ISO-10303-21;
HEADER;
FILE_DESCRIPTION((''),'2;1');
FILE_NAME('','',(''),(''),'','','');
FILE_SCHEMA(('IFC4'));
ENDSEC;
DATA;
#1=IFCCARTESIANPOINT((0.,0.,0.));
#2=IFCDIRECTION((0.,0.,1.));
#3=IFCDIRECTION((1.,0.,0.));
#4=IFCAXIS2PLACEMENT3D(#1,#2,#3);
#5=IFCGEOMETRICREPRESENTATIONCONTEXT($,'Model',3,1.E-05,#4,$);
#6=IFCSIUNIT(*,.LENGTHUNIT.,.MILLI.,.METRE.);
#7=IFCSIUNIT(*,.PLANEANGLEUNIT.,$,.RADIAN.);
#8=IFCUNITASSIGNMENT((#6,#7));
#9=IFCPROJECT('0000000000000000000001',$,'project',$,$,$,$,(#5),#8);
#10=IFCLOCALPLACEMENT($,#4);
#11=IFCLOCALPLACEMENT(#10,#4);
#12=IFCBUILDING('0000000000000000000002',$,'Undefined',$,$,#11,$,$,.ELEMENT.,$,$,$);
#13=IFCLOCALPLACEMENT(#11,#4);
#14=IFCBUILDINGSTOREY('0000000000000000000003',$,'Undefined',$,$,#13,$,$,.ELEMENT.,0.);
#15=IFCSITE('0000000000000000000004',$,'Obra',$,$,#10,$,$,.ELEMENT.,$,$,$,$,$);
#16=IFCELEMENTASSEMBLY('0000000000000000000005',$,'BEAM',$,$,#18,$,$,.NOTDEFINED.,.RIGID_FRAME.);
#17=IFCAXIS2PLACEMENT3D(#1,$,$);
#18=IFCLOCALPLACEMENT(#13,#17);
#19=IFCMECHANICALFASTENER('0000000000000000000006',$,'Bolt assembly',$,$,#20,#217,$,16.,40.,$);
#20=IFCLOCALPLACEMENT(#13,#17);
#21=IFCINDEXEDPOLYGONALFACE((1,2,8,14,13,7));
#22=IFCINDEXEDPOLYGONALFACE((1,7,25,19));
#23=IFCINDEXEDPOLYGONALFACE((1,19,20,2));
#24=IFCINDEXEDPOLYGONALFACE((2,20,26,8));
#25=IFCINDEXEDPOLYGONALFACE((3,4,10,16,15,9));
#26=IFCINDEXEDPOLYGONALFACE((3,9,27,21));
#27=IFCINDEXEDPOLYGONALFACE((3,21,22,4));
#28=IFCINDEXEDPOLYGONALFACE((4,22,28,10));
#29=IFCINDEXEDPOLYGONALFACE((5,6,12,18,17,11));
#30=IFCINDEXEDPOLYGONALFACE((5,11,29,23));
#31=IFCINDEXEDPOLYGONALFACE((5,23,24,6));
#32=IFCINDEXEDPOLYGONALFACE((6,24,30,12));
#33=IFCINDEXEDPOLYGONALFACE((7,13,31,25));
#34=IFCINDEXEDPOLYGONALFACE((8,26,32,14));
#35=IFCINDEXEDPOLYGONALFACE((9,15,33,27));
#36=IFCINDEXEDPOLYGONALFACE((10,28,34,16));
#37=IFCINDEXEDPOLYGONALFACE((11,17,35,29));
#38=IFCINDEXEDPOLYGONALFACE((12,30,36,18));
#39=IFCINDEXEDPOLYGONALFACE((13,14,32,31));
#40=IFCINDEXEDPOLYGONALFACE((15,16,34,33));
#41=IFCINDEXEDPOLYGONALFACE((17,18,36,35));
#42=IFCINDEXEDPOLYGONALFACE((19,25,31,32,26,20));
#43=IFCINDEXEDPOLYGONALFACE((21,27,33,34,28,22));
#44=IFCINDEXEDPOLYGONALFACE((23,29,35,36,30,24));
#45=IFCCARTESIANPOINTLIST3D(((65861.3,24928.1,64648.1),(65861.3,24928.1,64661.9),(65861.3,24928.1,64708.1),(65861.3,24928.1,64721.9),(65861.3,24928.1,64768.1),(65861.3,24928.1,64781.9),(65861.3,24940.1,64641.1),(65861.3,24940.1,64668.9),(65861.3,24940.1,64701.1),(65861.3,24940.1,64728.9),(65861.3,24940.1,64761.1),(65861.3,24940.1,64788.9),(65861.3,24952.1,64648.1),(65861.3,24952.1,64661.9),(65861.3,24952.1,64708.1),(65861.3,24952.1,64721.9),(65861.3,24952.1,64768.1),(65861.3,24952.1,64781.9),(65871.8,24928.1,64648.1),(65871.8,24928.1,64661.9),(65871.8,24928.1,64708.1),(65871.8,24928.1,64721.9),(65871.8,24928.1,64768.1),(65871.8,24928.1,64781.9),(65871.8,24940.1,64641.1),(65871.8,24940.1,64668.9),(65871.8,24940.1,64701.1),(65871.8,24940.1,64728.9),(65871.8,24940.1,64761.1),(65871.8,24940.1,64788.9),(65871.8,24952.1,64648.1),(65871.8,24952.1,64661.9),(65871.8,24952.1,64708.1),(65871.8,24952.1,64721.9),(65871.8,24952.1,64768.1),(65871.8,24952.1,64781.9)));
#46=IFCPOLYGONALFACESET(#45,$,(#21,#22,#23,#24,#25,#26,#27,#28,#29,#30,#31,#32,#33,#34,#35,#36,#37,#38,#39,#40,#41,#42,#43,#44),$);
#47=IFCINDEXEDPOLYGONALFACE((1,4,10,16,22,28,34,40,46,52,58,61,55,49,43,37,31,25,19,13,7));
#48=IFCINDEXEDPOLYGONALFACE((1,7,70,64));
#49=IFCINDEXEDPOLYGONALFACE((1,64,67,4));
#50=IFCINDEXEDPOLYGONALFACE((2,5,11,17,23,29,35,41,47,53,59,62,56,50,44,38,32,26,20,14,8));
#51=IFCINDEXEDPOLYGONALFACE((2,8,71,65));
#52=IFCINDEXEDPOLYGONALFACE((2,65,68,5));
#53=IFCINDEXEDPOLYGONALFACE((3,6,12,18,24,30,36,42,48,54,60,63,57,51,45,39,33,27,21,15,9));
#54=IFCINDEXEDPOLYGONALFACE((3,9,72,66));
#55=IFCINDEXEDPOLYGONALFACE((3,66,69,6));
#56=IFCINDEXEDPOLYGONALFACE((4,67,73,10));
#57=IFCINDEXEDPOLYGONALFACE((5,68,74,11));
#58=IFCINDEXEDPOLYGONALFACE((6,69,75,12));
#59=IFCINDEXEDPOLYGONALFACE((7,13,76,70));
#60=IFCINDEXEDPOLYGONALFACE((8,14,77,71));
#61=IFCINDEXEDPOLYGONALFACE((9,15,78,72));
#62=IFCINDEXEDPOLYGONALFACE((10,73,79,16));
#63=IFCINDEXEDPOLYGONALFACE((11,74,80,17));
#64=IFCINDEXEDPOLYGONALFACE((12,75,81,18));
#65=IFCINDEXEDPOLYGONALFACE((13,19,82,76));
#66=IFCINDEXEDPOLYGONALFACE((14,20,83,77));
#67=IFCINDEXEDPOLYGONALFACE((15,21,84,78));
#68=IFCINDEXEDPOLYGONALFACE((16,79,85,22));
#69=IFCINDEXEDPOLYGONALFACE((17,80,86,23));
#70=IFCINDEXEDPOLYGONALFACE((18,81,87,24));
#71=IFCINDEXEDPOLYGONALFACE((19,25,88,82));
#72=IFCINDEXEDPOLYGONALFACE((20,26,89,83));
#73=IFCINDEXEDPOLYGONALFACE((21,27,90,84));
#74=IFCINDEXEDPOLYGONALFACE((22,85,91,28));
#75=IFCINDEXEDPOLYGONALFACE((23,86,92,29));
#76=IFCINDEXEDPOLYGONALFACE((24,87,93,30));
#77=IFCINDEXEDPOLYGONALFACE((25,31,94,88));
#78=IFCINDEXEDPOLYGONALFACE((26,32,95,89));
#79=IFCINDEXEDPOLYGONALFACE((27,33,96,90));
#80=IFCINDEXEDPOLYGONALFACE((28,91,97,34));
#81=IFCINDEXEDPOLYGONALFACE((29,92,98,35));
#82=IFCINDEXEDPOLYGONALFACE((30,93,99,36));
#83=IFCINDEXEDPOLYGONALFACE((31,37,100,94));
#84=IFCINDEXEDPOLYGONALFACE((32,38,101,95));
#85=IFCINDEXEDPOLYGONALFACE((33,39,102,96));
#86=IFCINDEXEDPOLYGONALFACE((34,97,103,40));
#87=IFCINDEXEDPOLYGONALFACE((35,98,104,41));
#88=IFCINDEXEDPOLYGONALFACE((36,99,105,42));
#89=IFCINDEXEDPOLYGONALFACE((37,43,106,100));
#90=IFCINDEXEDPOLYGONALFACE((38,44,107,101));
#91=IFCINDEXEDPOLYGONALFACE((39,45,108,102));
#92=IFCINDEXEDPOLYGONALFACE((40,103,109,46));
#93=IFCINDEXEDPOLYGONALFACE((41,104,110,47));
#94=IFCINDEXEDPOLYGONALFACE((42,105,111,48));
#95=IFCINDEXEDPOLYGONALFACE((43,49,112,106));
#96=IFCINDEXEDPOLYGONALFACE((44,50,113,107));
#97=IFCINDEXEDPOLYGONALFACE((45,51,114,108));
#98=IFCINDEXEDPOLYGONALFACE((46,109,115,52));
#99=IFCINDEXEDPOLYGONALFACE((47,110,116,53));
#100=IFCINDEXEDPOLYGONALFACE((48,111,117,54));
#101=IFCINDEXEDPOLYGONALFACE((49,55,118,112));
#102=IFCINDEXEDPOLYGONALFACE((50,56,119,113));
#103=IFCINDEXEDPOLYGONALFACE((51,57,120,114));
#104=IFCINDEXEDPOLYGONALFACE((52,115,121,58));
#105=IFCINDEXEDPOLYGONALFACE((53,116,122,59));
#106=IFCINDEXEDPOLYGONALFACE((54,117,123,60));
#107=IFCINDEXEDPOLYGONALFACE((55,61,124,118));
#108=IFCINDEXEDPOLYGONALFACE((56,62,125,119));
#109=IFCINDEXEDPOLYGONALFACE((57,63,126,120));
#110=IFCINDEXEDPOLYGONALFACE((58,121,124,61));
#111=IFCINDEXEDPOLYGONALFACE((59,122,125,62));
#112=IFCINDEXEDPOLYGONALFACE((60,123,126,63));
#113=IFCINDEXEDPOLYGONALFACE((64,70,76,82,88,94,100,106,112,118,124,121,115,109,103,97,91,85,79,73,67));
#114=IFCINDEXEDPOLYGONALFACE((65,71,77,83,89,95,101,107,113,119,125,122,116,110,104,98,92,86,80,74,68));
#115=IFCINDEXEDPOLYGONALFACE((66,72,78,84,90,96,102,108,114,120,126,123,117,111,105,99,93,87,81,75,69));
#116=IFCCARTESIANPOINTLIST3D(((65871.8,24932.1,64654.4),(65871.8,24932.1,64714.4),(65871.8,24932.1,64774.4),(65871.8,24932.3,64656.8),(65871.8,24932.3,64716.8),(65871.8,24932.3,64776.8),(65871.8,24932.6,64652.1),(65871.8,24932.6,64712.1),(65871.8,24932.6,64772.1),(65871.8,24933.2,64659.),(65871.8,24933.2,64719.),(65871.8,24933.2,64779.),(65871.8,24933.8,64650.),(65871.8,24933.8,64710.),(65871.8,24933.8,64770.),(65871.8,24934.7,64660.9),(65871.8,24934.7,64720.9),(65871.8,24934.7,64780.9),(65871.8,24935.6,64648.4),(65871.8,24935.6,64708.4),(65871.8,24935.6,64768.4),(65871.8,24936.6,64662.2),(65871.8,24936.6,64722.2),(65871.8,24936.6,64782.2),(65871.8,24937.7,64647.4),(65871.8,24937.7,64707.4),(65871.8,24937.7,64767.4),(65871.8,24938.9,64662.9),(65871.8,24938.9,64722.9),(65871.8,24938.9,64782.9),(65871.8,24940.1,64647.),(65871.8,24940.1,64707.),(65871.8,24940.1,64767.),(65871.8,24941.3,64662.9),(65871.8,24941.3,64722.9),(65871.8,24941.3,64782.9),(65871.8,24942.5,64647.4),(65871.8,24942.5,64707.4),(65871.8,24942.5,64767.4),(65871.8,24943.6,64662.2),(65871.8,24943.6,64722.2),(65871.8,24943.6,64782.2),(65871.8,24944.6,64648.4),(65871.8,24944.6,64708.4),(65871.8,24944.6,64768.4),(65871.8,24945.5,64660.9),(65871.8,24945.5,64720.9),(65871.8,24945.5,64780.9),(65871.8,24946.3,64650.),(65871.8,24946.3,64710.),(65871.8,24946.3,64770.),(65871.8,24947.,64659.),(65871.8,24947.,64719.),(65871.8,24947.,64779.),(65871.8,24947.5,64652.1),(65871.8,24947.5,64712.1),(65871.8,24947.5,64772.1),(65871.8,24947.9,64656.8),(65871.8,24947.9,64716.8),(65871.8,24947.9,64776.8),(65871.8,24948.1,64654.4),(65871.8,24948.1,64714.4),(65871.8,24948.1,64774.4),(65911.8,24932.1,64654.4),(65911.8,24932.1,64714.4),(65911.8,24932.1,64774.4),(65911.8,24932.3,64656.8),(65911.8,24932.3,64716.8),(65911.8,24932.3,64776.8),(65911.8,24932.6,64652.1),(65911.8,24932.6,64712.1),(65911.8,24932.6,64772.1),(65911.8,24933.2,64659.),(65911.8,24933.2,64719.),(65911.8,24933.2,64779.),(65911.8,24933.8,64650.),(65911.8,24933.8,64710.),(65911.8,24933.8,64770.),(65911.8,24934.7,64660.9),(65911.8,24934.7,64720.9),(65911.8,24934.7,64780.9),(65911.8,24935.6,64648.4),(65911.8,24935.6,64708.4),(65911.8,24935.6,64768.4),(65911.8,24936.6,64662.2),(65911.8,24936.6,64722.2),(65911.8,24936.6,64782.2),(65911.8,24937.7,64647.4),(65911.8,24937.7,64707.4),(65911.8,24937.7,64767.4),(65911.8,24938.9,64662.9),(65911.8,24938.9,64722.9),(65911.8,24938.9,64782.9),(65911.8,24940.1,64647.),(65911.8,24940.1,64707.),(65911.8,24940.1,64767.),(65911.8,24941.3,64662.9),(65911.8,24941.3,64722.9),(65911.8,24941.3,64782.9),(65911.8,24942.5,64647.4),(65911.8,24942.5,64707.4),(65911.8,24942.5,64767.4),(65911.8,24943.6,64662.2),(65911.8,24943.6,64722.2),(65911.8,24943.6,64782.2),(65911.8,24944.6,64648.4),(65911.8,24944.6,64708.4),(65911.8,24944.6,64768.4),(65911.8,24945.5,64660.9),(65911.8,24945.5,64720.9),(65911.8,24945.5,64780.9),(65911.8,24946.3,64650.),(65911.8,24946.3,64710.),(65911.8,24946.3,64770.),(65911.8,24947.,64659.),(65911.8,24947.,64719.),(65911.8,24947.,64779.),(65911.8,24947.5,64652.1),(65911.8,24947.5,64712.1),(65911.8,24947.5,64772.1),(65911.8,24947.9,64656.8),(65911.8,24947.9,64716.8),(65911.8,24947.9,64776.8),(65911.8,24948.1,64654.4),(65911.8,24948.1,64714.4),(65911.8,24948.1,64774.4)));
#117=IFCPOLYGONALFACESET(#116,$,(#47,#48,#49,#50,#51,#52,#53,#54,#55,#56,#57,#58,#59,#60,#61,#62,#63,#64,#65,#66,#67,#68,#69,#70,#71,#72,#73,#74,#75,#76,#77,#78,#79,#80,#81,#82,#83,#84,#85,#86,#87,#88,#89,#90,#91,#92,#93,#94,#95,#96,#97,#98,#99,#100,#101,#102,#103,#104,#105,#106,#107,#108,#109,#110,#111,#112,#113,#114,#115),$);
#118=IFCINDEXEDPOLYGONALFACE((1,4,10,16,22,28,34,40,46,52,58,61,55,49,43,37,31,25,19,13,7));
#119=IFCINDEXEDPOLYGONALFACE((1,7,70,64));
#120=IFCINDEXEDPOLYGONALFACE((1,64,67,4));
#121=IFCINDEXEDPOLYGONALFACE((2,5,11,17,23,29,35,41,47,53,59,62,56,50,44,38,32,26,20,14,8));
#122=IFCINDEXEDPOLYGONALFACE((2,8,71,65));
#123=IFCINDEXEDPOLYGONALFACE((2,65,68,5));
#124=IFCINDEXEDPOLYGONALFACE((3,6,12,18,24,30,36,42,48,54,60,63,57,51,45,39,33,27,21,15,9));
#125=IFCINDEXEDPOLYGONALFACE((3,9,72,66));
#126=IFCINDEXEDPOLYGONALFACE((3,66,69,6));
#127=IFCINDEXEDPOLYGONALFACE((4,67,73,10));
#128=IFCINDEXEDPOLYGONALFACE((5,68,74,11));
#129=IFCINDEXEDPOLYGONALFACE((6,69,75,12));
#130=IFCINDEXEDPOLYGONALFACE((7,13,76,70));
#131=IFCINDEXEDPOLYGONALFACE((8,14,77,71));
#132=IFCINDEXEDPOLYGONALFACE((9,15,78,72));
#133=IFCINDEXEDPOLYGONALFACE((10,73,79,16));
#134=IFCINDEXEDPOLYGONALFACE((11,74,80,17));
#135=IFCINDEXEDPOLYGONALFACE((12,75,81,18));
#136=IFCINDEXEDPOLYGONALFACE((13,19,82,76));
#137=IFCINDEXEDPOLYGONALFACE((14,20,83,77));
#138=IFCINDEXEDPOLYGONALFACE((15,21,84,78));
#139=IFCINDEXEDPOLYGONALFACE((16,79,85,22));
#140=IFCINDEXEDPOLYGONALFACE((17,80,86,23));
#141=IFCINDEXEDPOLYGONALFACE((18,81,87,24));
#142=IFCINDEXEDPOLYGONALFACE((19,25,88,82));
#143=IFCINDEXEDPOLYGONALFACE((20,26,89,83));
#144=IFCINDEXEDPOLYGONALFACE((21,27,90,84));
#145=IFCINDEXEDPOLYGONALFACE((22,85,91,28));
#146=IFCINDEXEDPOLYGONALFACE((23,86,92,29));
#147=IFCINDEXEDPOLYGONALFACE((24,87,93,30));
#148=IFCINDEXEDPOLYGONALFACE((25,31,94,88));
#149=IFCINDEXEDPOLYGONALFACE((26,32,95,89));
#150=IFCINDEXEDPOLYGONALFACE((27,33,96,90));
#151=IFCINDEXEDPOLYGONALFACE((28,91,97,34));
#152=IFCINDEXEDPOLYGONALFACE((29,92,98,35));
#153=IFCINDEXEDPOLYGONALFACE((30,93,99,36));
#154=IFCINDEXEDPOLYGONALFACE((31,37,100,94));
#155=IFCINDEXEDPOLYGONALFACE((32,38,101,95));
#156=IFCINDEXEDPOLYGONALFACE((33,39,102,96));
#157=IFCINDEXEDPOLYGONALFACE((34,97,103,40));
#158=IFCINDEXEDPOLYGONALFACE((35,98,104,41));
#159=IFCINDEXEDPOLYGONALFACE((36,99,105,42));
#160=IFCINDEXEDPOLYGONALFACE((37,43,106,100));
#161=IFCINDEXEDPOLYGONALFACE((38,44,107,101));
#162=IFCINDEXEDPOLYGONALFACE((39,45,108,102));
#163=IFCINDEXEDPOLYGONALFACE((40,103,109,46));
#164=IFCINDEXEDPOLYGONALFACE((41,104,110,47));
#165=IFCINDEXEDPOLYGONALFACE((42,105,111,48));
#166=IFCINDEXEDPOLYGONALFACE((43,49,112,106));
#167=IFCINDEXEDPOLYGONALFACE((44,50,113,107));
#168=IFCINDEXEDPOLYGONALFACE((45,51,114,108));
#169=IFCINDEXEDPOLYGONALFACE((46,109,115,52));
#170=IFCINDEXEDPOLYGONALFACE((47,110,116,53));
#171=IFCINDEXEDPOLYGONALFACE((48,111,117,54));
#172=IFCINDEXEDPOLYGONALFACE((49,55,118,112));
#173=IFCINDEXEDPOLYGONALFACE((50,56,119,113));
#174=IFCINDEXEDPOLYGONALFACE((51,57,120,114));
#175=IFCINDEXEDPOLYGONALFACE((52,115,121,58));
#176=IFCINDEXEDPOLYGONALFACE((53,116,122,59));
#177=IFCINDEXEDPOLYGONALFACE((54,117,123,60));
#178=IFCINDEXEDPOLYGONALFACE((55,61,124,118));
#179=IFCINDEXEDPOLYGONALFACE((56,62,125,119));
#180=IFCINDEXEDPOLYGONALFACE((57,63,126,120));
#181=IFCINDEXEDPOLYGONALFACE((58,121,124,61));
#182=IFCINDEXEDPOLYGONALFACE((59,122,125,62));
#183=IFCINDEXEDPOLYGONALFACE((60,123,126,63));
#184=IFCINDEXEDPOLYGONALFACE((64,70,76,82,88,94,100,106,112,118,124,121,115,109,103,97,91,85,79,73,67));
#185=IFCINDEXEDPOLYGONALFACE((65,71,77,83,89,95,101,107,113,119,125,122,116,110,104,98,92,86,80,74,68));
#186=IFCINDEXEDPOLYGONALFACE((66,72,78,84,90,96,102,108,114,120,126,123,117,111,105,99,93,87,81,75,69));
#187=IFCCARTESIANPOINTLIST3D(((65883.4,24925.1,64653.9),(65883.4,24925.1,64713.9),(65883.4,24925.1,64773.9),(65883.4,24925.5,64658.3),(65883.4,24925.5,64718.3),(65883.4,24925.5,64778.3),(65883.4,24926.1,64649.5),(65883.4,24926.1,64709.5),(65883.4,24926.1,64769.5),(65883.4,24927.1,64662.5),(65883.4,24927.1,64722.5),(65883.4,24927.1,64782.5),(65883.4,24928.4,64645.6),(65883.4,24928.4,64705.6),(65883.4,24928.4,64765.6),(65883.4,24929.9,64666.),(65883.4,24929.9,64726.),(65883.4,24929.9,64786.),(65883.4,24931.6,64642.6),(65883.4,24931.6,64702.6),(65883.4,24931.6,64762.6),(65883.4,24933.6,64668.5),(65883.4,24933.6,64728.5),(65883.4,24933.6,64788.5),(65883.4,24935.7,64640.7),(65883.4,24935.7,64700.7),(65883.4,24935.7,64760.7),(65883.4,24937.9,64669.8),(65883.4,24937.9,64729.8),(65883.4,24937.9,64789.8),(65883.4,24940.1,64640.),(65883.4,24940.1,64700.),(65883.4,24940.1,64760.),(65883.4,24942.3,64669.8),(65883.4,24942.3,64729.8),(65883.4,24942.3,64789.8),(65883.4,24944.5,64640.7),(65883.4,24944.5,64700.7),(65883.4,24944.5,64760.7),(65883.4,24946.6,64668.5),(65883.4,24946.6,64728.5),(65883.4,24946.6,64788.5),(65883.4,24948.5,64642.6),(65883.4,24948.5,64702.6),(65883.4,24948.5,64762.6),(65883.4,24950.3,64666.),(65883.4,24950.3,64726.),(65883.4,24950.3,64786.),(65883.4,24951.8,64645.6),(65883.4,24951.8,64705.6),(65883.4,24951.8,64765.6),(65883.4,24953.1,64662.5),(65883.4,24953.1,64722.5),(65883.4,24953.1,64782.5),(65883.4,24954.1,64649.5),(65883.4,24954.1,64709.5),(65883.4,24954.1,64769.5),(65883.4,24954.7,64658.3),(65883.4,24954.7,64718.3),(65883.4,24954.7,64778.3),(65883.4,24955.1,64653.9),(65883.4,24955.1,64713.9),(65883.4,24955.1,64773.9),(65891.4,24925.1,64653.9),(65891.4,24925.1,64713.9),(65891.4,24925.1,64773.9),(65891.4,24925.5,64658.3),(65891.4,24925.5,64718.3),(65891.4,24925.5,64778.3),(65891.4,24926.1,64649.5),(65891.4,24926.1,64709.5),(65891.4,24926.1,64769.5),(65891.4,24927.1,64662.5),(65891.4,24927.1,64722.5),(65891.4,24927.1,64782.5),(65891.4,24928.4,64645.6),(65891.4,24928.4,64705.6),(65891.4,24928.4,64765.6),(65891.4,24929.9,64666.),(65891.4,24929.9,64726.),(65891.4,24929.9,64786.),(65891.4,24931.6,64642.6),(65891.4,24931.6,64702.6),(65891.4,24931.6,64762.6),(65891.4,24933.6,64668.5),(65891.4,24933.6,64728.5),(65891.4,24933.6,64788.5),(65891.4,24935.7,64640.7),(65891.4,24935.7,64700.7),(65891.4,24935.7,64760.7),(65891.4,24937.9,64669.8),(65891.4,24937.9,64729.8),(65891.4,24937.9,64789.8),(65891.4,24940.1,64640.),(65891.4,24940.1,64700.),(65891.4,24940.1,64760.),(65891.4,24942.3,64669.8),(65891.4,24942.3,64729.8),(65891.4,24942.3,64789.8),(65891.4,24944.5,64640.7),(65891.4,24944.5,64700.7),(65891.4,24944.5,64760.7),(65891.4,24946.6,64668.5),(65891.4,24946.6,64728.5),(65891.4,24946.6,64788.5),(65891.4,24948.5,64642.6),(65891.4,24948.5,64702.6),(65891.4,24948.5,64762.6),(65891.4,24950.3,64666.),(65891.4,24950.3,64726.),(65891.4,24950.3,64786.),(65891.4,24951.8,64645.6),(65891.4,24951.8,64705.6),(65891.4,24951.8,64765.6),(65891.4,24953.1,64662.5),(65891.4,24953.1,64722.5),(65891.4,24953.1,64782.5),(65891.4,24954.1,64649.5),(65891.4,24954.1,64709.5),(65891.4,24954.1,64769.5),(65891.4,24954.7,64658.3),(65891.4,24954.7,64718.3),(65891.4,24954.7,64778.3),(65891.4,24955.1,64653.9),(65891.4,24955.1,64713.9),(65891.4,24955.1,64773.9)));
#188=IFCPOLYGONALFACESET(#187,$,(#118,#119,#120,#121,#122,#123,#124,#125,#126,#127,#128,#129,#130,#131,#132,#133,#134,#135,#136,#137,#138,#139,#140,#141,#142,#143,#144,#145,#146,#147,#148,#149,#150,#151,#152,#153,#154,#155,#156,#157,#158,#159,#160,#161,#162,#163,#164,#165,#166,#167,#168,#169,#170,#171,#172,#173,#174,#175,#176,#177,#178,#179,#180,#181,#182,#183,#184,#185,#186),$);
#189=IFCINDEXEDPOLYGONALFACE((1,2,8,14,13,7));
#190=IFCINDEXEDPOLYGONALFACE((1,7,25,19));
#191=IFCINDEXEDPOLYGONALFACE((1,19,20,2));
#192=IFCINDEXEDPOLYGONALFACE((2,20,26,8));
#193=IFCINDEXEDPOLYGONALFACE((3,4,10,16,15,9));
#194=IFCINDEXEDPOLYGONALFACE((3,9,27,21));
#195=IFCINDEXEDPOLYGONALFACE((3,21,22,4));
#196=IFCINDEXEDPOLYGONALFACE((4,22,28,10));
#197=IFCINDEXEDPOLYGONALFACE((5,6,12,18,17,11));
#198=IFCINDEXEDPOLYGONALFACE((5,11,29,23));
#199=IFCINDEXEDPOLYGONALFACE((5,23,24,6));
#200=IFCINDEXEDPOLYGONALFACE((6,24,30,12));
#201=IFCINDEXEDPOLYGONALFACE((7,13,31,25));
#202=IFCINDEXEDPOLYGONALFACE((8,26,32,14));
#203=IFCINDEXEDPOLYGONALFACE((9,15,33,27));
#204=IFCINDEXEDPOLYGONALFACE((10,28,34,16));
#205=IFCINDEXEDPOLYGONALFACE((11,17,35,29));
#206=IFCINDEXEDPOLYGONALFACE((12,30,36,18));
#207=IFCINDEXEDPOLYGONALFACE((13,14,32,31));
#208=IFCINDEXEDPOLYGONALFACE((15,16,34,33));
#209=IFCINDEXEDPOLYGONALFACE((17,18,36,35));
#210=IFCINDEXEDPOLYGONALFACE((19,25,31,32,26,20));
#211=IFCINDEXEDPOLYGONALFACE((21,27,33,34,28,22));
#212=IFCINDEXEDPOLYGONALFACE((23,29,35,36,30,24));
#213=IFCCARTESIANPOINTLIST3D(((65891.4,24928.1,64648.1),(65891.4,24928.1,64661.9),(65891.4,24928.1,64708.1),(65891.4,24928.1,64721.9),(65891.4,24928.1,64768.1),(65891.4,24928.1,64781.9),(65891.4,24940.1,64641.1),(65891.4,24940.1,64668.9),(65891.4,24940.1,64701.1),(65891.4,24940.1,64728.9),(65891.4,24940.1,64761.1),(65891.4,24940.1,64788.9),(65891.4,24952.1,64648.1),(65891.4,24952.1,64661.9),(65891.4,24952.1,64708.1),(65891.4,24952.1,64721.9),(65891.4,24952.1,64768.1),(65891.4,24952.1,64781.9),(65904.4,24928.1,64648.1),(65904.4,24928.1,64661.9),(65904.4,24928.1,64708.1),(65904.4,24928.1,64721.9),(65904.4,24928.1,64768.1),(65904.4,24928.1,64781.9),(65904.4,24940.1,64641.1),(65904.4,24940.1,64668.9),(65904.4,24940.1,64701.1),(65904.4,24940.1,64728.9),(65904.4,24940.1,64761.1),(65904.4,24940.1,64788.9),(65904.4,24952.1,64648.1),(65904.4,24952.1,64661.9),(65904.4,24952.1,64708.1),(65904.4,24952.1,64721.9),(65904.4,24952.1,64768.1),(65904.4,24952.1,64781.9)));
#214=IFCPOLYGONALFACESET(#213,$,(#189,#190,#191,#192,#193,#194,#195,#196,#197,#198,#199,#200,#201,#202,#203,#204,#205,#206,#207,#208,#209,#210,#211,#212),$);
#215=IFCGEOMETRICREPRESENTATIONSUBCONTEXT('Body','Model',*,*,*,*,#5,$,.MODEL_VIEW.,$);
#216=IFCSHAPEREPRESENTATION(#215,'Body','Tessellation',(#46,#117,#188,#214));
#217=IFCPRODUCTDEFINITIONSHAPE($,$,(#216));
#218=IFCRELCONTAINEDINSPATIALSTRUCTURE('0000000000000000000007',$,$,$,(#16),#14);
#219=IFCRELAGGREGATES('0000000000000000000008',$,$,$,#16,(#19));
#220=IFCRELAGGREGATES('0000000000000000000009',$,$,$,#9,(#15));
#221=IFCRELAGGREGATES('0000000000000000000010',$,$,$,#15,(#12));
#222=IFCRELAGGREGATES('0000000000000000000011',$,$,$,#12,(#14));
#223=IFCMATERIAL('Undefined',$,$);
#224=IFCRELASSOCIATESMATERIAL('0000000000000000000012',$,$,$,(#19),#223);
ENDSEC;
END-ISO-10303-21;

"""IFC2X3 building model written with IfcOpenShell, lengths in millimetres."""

from ifc_helpers import new_model, si_unit, frame, origin_with_axes, origin_2d_with_axis, place, context, subcontext, project, spatial, polyline, circle, outline, extrude, source, transform, mapped, material, element, aggregate, save


model = new_model("IFC2X3")

# Units and contexts
model_context = context("Model", 3, precision=1e-05, world=origin_with_axes())
body_context = subcontext(model_context, "Body", "Model", "MODEL_VIEW")
ifc_project = project(units=[si_unit("LENGTHUNIT", "METRE", prefix="MILLI"), si_unit("PLANEANGLEUNIT", "RADIAN")], contexts=[model_context])

# Site, building, storey
site_placement = place(None, origin_with_axes())
site = spatial("IfcSite", under=ifc_project, at=site_placement, Name="Obra", CompositionType="ELEMENT")
building_placement = place(site_placement, origin_with_axes())
building = spatial("IfcBuilding", under=site, at=building_placement, Name="Undefined", CompositionType="ELEMENT")
storey_placement = place(building_placement, origin_with_axes())
storey = spatial("IfcBuildingStorey", under=building, at=storey_placement, Name="Undefined", CompositionType="ELEMENT", Elevation=0.0)

# Shared definitions
ifc_material_1 = material(Name="Undefined")

# Element assembly, mechanical fastener
assembly_1_placement = place(storey_placement, origin_with_axes())
assembly_1 = element("IfcElementAssembly", 1, at=assembly_1_placement, inside=storey, Name="BEAM", AssemblyPlace="NOTDEFINED", PredefinedType="RIGID_FRAME")
shared_shape_1 = source(origin_with_axes(), body_context, "Body", "SweptSolid", [
    extrude(outline(polyline([(13.9, 0.0), (6.9, 12.0), (-6.9, 12.0), (-13.9, 0.0), (-6.9, -12.0), (6.9, -12.0), (13.9, 0.0)])), frame((0.0, -19.7, 0.0), z_axis=(0.0, 1.0, 0.0), x_axis=(1.0, 0.0, 0.0)), (0.0, 0.0, 1.0), 10.6),
    extrude(circle(Radius=8.0, at=origin_2d_with_axis()), frame((0.0, -9.1, 0.0), z_axis=(0.0, 1.0, 0.0), x_axis=(1.0, 0.0, 0.0)), (0.0, 0.0, 1.0), 40.0),
    extrude(circle(Radius=15.0, at=origin_2d_with_axis()), frame((0.0, 2.5, 0.0), z_axis=(0.0, 1.0, 0.0), x_axis=(1.0, 0.0, 0.0)), (0.0, 0.0, 1.0), 8.0),
    extrude(outline(polyline([(13.9, 0.0), (6.9, 12.0), (-6.9, 12.0), (-13.9, 0.0), (-6.9, -12.0), (6.9, -12.0), (13.9, 0.0)])), frame((0.0, 10.5, 0.0), z_axis=(0.0, 1.0, 0.0), x_axis=(1.0, 0.0, 0.0)), (0.0, 0.0, 1.0), 13.0),
])
mechanical_fastener_1_placement = place(assembly_1_placement, frame((65880.9, 24990.1, 64835.0), z_axis=(0.000002, -1.0, 0.0), x_axis=(0.0, 0.0, -1.0)))
mechanical_fastener_1 = element("IfcMechanicalFastener", 2, at=mechanical_fastener_1_placement, material=ifc_material_1, Name="Bolt assembly", NominalDiameter=16.0, NominalLength=40.0, context=body_context, shape_type="MappedRepresentation", body=[
    mapped(shared_shape_1, transform((60.0, 0.0, 50.0))),
    mapped(shared_shape_1, transform((120.0, 0.0, 50.0))),
    mapped(shared_shape_1, transform((180.0, 0.0, 50.0))),
])
aggregate(assembly_1, [mechanical_fastener_1])

save(model, "model.ifc")
